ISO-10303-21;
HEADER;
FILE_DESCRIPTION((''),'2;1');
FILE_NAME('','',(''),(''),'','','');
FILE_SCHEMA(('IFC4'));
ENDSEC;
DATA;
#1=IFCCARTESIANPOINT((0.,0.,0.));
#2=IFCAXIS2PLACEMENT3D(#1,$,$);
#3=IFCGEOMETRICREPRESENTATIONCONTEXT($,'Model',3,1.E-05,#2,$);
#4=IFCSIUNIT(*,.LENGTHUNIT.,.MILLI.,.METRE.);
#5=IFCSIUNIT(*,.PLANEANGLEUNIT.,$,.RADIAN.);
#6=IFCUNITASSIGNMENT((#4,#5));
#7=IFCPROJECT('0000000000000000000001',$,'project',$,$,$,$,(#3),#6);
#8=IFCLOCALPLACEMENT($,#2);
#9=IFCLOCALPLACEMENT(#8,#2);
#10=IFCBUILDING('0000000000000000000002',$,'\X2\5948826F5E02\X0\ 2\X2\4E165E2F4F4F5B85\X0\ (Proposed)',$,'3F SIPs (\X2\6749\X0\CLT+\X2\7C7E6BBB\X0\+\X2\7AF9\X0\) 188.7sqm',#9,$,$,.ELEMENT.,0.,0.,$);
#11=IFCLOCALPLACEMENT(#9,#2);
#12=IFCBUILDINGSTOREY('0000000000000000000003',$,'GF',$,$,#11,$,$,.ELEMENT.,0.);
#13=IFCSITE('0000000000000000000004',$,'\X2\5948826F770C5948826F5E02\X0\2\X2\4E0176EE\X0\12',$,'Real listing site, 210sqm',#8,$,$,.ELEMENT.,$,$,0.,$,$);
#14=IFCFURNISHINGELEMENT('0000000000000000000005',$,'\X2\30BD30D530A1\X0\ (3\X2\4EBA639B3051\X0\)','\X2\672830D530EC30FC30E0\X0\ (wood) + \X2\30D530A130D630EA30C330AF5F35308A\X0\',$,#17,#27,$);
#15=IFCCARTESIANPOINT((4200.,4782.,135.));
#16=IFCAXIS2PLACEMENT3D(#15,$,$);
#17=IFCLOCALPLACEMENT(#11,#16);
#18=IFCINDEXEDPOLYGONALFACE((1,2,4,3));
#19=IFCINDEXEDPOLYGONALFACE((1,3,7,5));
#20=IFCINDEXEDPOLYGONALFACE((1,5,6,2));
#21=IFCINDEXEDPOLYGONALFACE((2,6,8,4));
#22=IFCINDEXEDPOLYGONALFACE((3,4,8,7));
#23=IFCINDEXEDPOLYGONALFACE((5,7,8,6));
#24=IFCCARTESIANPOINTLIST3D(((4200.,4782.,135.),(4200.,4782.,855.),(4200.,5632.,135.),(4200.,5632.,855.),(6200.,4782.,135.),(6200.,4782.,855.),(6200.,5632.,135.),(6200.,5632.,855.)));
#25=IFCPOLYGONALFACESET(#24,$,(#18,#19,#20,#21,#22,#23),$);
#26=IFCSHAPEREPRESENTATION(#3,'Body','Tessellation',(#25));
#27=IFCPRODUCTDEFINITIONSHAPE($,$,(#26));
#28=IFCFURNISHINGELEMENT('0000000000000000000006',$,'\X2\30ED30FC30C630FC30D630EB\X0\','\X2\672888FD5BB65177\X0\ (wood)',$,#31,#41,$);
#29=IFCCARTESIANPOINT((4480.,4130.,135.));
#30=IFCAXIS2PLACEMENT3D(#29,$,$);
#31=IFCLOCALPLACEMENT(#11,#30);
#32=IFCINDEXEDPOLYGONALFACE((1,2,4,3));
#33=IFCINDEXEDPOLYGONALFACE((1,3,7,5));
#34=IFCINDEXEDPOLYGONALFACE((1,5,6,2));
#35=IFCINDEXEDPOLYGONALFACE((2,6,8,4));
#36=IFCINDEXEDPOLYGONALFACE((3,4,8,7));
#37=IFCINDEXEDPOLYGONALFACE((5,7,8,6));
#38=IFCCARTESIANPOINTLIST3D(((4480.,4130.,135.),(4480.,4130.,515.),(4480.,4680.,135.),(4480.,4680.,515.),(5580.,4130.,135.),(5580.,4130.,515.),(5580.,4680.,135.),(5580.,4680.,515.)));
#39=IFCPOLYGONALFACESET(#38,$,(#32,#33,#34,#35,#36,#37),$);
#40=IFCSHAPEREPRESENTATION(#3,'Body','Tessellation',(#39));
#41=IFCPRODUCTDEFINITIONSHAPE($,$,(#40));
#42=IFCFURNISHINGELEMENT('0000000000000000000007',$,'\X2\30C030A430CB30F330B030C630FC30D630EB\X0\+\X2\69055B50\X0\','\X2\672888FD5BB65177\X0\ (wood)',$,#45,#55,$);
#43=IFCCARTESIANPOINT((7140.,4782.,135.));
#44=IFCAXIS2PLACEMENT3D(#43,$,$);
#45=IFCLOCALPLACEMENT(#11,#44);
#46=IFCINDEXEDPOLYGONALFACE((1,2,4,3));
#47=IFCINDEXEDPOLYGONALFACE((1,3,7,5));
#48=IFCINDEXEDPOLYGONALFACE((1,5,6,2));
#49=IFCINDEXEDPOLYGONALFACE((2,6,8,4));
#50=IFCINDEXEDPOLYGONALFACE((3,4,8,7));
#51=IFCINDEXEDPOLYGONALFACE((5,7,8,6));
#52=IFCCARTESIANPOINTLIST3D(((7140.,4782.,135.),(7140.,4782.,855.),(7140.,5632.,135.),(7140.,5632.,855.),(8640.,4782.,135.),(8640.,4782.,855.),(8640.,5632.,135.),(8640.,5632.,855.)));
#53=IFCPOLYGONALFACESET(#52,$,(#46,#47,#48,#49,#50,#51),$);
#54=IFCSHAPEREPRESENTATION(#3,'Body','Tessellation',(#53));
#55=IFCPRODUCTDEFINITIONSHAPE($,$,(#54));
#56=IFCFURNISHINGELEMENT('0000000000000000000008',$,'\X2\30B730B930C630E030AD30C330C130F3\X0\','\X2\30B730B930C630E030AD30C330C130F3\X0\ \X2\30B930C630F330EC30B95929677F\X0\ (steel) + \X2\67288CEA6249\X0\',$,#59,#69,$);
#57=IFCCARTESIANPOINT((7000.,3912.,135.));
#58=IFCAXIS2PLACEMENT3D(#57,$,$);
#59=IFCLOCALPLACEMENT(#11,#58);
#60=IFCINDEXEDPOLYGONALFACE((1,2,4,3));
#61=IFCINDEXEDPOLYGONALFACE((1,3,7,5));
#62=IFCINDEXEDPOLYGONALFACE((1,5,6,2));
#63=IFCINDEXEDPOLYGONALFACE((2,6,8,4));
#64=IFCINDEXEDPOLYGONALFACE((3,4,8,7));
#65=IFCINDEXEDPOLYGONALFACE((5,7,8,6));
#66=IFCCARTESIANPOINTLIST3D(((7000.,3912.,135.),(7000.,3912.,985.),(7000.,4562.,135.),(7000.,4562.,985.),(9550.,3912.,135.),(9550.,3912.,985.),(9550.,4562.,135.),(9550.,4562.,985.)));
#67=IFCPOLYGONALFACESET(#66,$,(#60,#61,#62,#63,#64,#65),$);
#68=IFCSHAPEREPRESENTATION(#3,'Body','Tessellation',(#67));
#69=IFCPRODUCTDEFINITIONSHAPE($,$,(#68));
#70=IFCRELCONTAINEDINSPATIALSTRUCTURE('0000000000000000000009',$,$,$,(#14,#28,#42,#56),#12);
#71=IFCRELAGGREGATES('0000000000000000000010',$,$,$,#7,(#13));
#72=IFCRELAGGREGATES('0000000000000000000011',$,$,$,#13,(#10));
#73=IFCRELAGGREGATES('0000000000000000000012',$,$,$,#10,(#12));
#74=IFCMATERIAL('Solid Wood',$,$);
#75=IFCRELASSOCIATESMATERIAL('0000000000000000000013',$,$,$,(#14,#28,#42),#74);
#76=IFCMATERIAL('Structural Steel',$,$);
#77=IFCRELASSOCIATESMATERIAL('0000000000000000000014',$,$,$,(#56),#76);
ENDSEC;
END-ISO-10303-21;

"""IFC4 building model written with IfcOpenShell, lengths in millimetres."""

from ifc_helpers import new_model, si_unit, frame, frame_2d, origin, place, context, project, spatial, rectangle, extrude, material, element, save


model = new_model("IFC4")

# Units and contexts
model_context = context("Model", 3, precision=1e-05, world=origin())
ifc_project = project(units=[si_unit("LENGTHUNIT", "METRE", prefix="MILLI"), si_unit("PLANEANGLEUNIT", "RADIAN")], contexts=[model_context])

# Site, building, storey
site_placement = place(None, origin())
site = spatial("IfcSite", under=ifc_project, at=site_placement, Name="奈良県奈良市2丁目12", ObjectType="Real listing site, 210sqm", CompositionType="ELEMENT", RefElevation=0.0)
building_placement = place(site_placement, origin())
building = spatial("IfcBuilding", under=site, at=building_placement, Name="奈良市 2世帯住宅 (Proposed)", ObjectType="3F SIPs (杉CLT+籾殻+竹) 188.7sqm", CompositionType="ELEMENT", ElevationOfRefHeight=0.0, ElevationOfTerrain=0.0)
storey_placement = place(building_placement, origin())
storey = spatial("IfcBuildingStorey", under=building, at=storey_placement, Name="GF", CompositionType="ELEMENT", Elevation=0.0)

# Shared definitions
ifc_material_1 = material(Name="Solid Wood")

# Furnishing elements
furnishing_1_placement = place(storey_placement, frame((4200.0, 4782.0, 135.0)))
element("IfcFurnishingElement", 1, at=furnishing_1_placement, inside=storey, material=ifc_material_1, Name="ソファ (3人掛け)", Description="木フレーム (wood) + ファブリック張り", context=model_context, shape_type="SweptSolid", body=[
    extrude(rectangle(XDim=2000.0, YDim=850.0, at=frame_2d((1000.0, 425.0))), frame((4200.0, 4782.0, 135.0)), (0.0, 0.0, 1.0), 720.0),
])
furnishing_2_placement = place(storey_placement, frame((4480.0, 4130.0, 135.0)))
element("IfcFurnishingElement", 2, at=furnishing_2_placement, inside=storey, material=ifc_material_1, Name="ローテーブル", Description="木製家具 (wood)", context=model_context, shape_type="SweptSolid", body=[
    extrude(rectangle(XDim=1100.0, YDim=550.0, at=frame_2d((550.0, 275.0))), frame((4480.0, 4130.0, 135.0)), (0.0, 0.0, 1.0), 380.0),
])
furnishing_3_placement = place(storey_placement, frame((7140.0, 4782.0, 135.0)))
element("IfcFurnishingElement", 3, at=furnishing_3_placement, inside=storey, material=ifc_material_1, Name="ダイニングテーブル+椅子", Description="木製家具 (wood)", context=model_context, shape_type="SweptSolid", body=[
    extrude(rectangle(XDim=1500.0, YDim=850.0, at=frame_2d((750.0, 425.0))), frame((7140.0, 4782.0, 135.0)), (0.0, 0.0, 1.0), 720.0),
])
ifc_material_2 = material(Name="Structural Steel")
furnishing_4_placement = place(storey_placement, frame((7000.0, 3912.0, 135.0)))
element("IfcFurnishingElement", 4, at=furnishing_4_placement, inside=storey, material=ifc_material_2, Name="システムキッチン", Description="システムキッチン ステンレス天板 (steel) + 木質扉", context=model_context, shape_type="SweptSolid", body=[
    extrude(rectangle(XDim=2550.0, YDim=650.0, at=frame_2d((1275.0, 325.0))), frame((7000.0, 3912.0, 135.0)), (0.0, 0.0, 1.0), 850.0),
])

save(model, "model.ifc")
